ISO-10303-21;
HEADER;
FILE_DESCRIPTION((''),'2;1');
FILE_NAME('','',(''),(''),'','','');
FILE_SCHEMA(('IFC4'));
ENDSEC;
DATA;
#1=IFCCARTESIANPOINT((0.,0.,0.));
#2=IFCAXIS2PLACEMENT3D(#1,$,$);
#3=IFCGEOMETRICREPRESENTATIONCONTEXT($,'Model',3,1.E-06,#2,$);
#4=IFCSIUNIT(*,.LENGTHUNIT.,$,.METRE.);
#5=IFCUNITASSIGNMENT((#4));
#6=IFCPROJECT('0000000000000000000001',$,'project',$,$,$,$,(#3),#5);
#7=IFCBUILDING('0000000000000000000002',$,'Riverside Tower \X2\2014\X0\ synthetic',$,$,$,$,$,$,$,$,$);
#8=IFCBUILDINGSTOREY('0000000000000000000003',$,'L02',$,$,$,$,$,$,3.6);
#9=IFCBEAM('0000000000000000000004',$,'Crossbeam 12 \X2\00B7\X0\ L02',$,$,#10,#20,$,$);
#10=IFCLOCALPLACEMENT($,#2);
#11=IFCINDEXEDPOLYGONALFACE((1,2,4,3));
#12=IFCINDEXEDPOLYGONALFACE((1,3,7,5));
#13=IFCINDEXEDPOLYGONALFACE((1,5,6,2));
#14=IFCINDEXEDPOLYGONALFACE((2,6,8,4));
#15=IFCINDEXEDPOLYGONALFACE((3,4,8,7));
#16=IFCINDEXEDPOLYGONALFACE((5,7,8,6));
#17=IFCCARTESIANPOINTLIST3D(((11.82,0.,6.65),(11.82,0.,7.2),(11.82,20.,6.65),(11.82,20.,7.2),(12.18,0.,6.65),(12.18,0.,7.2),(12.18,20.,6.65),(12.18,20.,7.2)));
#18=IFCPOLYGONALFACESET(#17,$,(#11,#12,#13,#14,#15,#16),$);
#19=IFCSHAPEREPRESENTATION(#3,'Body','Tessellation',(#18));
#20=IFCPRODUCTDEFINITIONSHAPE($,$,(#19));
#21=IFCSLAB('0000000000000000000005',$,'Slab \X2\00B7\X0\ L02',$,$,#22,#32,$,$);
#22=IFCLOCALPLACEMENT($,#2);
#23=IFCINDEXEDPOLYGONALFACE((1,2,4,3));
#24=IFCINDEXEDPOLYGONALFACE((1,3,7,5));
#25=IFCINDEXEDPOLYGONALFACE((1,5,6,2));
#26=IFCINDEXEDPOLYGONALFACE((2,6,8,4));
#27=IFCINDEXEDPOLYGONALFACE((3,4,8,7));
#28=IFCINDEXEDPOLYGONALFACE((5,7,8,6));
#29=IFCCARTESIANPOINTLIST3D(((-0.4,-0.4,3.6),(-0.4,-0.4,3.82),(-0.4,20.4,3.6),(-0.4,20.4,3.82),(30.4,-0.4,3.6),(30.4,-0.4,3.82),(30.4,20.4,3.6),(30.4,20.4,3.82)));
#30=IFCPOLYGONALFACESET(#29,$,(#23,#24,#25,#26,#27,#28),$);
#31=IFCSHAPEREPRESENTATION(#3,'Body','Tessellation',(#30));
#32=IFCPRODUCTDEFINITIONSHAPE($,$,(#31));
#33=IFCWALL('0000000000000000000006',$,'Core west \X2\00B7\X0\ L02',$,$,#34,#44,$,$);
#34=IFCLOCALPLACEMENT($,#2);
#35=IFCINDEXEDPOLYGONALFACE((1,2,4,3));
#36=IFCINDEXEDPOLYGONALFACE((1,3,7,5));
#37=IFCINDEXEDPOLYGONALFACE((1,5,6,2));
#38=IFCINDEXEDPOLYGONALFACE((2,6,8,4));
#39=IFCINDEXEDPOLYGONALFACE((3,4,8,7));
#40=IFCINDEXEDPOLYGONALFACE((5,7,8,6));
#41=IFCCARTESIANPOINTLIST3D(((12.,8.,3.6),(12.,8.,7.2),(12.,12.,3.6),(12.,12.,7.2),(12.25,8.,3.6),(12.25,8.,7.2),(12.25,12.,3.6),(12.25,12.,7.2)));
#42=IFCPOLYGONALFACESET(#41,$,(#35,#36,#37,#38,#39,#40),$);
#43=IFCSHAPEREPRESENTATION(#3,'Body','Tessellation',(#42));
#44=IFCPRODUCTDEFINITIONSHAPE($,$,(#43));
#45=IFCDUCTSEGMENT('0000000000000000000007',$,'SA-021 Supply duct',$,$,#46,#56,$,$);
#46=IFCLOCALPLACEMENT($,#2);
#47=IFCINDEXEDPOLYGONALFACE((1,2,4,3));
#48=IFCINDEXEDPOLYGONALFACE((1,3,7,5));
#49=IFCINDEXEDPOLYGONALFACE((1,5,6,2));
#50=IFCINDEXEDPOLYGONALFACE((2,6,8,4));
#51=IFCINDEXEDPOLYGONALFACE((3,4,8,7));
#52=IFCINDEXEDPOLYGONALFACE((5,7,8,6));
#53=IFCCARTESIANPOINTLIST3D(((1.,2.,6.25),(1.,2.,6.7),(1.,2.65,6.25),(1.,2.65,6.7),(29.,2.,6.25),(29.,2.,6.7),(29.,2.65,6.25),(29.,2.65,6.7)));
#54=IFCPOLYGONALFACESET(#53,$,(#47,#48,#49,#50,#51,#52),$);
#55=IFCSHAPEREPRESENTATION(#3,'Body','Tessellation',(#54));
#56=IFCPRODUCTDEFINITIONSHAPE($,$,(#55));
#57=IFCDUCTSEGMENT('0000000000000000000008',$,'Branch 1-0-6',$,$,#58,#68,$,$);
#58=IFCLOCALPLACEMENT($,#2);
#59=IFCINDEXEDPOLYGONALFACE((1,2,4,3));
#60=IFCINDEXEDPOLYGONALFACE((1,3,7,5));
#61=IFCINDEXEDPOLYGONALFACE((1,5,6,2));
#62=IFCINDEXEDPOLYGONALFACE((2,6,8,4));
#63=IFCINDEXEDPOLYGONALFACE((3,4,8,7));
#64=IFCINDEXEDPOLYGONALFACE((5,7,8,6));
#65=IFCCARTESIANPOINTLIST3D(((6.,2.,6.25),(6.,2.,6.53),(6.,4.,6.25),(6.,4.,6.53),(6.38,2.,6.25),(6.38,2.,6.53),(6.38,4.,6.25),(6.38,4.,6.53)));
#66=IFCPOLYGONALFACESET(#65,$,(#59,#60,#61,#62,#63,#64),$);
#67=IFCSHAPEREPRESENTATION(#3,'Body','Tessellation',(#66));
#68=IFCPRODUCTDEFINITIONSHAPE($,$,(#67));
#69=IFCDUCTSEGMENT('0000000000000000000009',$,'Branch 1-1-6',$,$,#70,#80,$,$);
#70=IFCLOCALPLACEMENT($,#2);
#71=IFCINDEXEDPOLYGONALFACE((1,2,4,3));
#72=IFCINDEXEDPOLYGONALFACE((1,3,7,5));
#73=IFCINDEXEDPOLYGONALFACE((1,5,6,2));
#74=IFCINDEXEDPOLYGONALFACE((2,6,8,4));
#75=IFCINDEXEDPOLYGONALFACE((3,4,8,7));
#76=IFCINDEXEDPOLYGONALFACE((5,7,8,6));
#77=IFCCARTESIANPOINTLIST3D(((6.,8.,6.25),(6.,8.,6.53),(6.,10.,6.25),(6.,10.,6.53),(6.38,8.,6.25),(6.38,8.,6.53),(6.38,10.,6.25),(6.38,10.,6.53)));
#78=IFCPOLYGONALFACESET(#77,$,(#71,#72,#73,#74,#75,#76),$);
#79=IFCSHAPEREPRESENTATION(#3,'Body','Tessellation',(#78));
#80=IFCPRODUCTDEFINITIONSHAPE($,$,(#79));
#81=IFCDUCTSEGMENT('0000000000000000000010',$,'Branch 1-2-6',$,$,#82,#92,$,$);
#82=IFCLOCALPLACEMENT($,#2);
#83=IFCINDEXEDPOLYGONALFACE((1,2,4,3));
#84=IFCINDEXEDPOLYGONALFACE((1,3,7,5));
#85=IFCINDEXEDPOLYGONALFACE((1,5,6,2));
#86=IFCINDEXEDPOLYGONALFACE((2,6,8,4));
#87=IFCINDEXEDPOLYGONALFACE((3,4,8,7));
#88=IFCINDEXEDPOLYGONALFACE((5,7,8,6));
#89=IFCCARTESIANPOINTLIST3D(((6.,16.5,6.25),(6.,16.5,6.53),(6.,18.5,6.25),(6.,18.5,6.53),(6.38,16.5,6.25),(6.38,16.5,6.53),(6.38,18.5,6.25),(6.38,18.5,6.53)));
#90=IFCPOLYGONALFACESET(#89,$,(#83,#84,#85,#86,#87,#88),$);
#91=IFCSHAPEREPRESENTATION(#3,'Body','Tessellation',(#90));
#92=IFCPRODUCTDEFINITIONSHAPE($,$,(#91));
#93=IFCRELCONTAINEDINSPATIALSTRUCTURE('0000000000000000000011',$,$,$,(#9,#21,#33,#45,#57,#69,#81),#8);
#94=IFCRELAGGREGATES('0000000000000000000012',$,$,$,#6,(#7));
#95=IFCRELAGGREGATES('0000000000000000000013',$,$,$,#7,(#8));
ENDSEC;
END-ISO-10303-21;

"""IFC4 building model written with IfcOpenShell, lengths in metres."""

from ifc_helpers import new_model, si_unit, frame, origin, place, context, project, spatial, rectangle, extrude, element, save


model = new_model("IFC4")

# Units and contexts
model_context = context("Model", 3, precision=1e-06, world=origin())
ifc_project = project(units=[si_unit("LENGTHUNIT", "METRE")], contexts=[model_context])

# Building, storey
building = spatial("IfcBuilding", under=ifc_project, Name="Riverside Tower — synthetic")
storey = spatial("IfcBuildingStorey", under=building, Name="L02", Elevation=3.6)

# Beam
for number, where, name in (
    (1, (12.0, 10.0, 6.65), "Crossbeam 12 · L02"),
):
    element("IfcBeam", number, at=place(None, frame(where)), inside=storey, Name=name, context=model_context, shape_type="SweptSolid", body=[
        extrude(rectangle(XDim=0.36, YDim=20.0), origin(), (0.0, 0.0, 1.0), 0.55),
    ])

# Slab
slab_placement = place(None, frame((15.0, 10.0, 3.6)))
element("IfcSlab", 2, at=slab_placement, inside=storey, Name="Slab · L02", context=model_context, shape_type="SweptSolid", body=[
    extrude(rectangle(XDim=30.8, YDim=20.8), origin(), (0.0, 0.0, 1.0), 0.22),
])

# Wall
wall_placement = place(None, frame((12.125, 10.0, 3.6)))
element("IfcWall", 3, at=wall_placement, inside=storey, Name="Core west · L02", context=model_context, shape_type="SweptSolid", body=[
    extrude(rectangle(XDim=0.25, YDim=4.0), origin(), (0.0, 0.0, 1.0), 3.6),
])

# Duct segments
duct_segment_placement = place(None, frame((15.0, 2.325, 6.25)))
element("IfcDuctSegment", 4, at=duct_segment_placement, inside=storey, Name="SA-021 Supply duct", context=model_context, shape_type="SweptSolid", body=[
    extrude(rectangle(XDim=28.0, YDim=0.65), origin(), (0.0, 0.0, 1.0), 0.45),
])
for number, where, name in (
    (5, (6.19, 3.0, 6.25), "Branch 1-0-6"),
    (6, (6.19, 9.0, 6.25), "Branch 1-1-6"),
    (7, (6.19, 17.5, 6.25), "Branch 1-2-6"),
):
    element("IfcDuctSegment", number, at=place(None, frame(where)), inside=storey, Name=name, context=model_context, shape_type="SweptSolid", body=[
        extrude(rectangle(XDim=0.38, YDim=2.0), origin(), (0.0, 0.0, 1.0), 0.28),
    ])

save(model, "model.ifc")
